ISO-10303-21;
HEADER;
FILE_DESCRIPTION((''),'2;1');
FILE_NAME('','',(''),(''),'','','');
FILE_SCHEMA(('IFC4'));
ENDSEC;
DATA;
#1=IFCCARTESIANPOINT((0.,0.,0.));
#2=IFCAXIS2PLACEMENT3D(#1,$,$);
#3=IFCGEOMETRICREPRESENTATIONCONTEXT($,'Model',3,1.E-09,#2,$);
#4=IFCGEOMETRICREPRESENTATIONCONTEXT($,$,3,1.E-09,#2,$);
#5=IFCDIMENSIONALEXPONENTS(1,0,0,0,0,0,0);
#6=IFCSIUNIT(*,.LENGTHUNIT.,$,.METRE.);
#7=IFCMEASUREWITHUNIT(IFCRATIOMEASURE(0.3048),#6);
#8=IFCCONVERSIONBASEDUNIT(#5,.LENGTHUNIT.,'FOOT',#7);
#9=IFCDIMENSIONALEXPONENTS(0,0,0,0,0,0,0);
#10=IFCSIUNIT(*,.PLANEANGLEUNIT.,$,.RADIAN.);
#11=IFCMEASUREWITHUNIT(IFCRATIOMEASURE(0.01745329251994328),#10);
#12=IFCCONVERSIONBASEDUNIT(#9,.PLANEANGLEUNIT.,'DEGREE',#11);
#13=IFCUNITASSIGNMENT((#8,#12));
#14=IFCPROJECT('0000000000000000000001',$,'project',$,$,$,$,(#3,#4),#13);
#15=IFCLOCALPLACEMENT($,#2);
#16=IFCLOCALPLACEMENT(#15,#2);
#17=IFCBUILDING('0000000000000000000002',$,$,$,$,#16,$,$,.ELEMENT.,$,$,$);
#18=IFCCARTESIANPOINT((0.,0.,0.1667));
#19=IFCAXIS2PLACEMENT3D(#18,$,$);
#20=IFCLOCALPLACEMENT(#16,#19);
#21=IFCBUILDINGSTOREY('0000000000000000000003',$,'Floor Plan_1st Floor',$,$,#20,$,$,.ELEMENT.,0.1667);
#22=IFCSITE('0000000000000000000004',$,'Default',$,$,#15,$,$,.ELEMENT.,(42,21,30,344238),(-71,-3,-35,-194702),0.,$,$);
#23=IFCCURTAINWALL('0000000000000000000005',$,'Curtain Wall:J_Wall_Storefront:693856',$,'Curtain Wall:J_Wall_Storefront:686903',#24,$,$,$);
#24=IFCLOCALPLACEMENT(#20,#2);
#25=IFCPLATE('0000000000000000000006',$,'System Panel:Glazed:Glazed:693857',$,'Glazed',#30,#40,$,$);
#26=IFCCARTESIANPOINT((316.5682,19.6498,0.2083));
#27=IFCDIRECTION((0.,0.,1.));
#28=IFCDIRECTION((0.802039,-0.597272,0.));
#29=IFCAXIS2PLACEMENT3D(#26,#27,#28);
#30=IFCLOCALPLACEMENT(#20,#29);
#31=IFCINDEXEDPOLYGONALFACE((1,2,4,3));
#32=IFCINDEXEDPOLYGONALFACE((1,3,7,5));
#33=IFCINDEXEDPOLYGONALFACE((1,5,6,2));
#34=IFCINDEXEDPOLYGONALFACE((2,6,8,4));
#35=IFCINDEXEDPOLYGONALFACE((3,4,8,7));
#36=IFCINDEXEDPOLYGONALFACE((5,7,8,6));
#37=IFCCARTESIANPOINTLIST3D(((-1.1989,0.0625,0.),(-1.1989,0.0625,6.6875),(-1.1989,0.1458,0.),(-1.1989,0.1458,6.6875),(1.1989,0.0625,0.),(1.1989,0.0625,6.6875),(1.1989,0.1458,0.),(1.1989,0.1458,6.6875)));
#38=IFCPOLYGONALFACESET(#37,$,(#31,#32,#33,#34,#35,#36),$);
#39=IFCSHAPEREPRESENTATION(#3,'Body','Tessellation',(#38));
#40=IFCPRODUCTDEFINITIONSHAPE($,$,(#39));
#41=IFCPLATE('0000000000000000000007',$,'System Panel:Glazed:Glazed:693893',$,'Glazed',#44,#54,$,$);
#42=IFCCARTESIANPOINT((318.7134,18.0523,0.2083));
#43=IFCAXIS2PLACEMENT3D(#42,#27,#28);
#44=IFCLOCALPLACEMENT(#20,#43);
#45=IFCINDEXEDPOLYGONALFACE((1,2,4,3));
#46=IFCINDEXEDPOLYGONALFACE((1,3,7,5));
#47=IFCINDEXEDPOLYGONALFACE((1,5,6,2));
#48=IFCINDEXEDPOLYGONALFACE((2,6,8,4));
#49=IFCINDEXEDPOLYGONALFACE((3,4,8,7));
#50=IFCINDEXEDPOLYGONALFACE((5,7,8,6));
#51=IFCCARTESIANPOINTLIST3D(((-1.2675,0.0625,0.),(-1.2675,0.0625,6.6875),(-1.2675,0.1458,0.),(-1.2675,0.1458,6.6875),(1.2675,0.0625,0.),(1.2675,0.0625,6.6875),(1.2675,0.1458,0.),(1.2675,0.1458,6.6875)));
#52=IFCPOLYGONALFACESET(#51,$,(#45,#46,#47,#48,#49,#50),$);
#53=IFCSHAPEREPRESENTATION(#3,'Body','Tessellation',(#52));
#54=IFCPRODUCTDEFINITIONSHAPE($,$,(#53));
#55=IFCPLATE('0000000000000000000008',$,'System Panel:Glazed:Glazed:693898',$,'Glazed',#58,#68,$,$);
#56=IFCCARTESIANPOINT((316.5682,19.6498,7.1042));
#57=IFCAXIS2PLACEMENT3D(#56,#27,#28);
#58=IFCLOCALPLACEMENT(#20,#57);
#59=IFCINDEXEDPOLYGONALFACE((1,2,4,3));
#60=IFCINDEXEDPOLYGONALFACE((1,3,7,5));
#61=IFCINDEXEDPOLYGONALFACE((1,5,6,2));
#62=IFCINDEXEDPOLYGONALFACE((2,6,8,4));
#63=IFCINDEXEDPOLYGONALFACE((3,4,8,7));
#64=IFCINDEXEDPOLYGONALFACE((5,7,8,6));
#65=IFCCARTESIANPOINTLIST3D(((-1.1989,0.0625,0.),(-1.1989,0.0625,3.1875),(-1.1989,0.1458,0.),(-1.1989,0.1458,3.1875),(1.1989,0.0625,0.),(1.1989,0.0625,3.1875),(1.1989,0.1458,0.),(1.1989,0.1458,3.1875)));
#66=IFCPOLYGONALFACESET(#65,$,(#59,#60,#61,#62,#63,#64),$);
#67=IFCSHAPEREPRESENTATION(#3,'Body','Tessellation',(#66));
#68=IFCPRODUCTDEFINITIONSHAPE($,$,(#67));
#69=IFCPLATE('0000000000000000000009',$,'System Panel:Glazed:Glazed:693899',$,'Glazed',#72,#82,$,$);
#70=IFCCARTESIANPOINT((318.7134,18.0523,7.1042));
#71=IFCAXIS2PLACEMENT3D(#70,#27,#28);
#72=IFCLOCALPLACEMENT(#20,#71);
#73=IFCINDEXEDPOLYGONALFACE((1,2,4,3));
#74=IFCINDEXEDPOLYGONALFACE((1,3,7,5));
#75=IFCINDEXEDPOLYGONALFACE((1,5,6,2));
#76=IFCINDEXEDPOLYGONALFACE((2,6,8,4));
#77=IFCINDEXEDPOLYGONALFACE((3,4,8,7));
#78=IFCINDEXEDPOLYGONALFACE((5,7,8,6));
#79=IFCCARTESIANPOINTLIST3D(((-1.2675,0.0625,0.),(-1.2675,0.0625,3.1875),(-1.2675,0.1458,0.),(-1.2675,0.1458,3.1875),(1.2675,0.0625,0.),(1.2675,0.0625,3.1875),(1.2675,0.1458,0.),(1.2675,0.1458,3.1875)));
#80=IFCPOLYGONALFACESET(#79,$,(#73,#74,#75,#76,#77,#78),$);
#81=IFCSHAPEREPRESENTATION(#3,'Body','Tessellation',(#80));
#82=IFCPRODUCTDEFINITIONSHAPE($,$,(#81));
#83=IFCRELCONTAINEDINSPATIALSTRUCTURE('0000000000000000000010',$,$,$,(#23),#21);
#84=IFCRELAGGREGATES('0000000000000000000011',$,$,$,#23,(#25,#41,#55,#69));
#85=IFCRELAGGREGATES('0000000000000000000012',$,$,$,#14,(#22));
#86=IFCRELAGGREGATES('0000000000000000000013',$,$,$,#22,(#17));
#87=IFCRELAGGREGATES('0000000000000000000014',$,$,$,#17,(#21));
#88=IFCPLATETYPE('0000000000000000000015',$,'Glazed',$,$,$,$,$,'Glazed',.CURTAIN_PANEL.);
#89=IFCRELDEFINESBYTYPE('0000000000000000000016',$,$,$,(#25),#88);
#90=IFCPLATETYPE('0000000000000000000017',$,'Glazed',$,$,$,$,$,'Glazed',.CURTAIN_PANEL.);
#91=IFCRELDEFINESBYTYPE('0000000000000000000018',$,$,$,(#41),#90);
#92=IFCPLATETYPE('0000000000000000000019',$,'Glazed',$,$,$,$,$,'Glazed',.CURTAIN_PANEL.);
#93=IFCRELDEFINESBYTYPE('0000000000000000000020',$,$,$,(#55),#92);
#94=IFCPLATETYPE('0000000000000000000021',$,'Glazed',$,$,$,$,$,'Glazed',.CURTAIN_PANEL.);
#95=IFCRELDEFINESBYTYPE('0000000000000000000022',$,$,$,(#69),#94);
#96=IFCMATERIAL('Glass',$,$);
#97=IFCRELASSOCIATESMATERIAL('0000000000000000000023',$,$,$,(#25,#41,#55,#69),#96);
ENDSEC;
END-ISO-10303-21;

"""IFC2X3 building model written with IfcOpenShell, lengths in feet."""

from ifc_helpers import new_model, entity, si_unit, converted_unit, frame, origin, origin_2d_with_axis, place, context, project, spatial, rectangle, extrude, source, transform, mapped, material, type_object, type_shapes, element, aggregate, save


model = new_model("IFC2X3")

# Units and contexts
model_context = context("Model", 3, precision=1e-09, world=origin())
context_of_model = context(None, 3, precision=1e-09, world=origin())
ifc_project = project(units=[converted_unit("LENGTHUNIT", "FOOT", entity("IfcRatioMeasure", 0.3048), si_unit("LENGTHUNIT", "METRE"), dimensions=[1, 0, 0, 0, 0, 0, 0]), converted_unit("PLANEANGLEUNIT", "DEGREE", entity("IfcRatioMeasure", 0.01745329251994328), si_unit("PLANEANGLEUNIT", "RADIAN"), dimensions=[0, 0, 0, 0, 0, 0, 0])], contexts=[model_context, context_of_model])

# Site, building, storey
site_placement = place(None, origin())
site = spatial("IfcSite", under=ifc_project, at=site_placement, Name="Default", CompositionType="ELEMENT", RefLatitude=(42, 21, 30, 344238), RefLongitude=(-71, -3, -35, -194702), RefElevation=0.0)
building_placement = place(site_placement, origin())
building = spatial("IfcBuilding", under=site, at=building_placement, CompositionType="ELEMENT")
storey_placement = place(building_placement, frame((0.0, 0.0, 0.1667)))
storey = spatial("IfcBuildingStorey", under=building, at=storey_placement, Name="Floor Plan_1st Floor", CompositionType="ELEMENT", Elevation=0.1667)

# Curtain wall
curtain_wall_placement = place(storey_placement, origin())
curtain_wall = element("IfcCurtainWall", 1, at=curtain_wall_placement, inside=storey, Name="Curtain Wall:J_Wall_Storefront:693856", ObjectType="Curtain Wall:J_Wall_Storefront:686903")

# Plates
ifc_material_1 = material(Name="Glass")
plate_type_1 = type_object("IfcPlateType", Name="Glazed", ElementType="Glazed", PredefinedType="CURTAIN_PANEL")
shared_shape_1 = source(origin(), model_context, "Body", "SweptSolid", [
    extrude(rectangle(XDim=0.0833, YDim=2.3978, at=origin_2d_with_axis()), frame((0.0, 0.1042, 0.0), z_axis=(0.0, 0.0, 1.0), x_axis=(0.0, 1.0, 0.0)), (0.0, 0.0, 1.0), 6.6875),
])
type_shapes(plate_type_1, [shared_shape_1])
plate_1_placement = place(storey_placement, frame((316.5682, 19.6498, 0.2083), z_axis=(0.0, 0.0, 1.0), x_axis=(0.802039, -0.597272, 0.0)))
plate_1 = element("IfcPlate", 2, at=plate_1_placement, type_object=plate_type_1, material=ifc_material_1, Name="System Panel:Glazed:Glazed:693857", ObjectType="Glazed", context=model_context, shape_type="MappedRepresentation", body=[
    mapped(shared_shape_1, transform((0.0, 0.0, 0.0), scale=1.0)),
])
plate_type_2 = type_object("IfcPlateType", Name="Glazed", ElementType="Glazed", PredefinedType="CURTAIN_PANEL")
shared_shape_2 = source(origin(), model_context, "Body", "SweptSolid", [
    extrude(rectangle(XDim=0.0833, YDim=2.5351, at=origin_2d_with_axis()), frame((0.0, 0.1042, 0.0), z_axis=(0.0, 0.0, 1.0), x_axis=(0.0, 1.0, 0.0)), (0.0, 0.0, 1.0), 6.6875),
])
type_shapes(plate_type_2, [shared_shape_2])
plate_2_placement = place(storey_placement, frame((318.7134, 18.0523, 0.2083), z_axis=(0.0, 0.0, 1.0), x_axis=(0.802039, -0.597272, 0.0)))
plate_2 = element("IfcPlate", 3, at=plate_2_placement, type_object=plate_type_2, material=ifc_material_1, Name="System Panel:Glazed:Glazed:693893", ObjectType="Glazed", context=model_context, shape_type="MappedRepresentation", body=[
    mapped(shared_shape_2, transform((0.0, 0.0, 0.0), scale=1.0)),
])
plate_type_3 = type_object("IfcPlateType", Name="Glazed", ElementType="Glazed", PredefinedType="CURTAIN_PANEL")
shared_shape_3 = source(origin(), model_context, "Body", "SweptSolid", [
    extrude(rectangle(XDim=0.0833, YDim=2.3978, at=origin_2d_with_axis()), frame((0.0, 0.1042, 0.0), z_axis=(0.0, 0.0, 1.0), x_axis=(0.0, 1.0, 0.0)), (0.0, 0.0, 1.0), 3.1875),
])
type_shapes(plate_type_3, [shared_shape_3])
plate_3_placement = place(storey_placement, frame((316.5682, 19.6498, 7.1042), z_axis=(0.0, 0.0, 1.0), x_axis=(0.802039, -0.597272, 0.0)))
plate_3 = element("IfcPlate", 4, at=plate_3_placement, type_object=plate_type_3, material=ifc_material_1, Name="System Panel:Glazed:Glazed:693898", ObjectType="Glazed", context=model_context, shape_type="MappedRepresentation", body=[
    mapped(shared_shape_3, transform((0.0, 0.0, 0.0), scale=1.0)),
])
plate_type_4 = type_object("IfcPlateType", Name="Glazed", ElementType="Glazed", PredefinedType="CURTAIN_PANEL")
shared_shape_4 = source(origin(), model_context, "Body", "SweptSolid", [
    extrude(rectangle(XDim=0.0833, YDim=2.5351, at=origin_2d_with_axis()), frame((0.0, 0.1042, 0.0), z_axis=(0.0, 0.0, 1.0), x_axis=(0.0, 1.0, 0.0)), (0.0, 0.0, 1.0), 3.1875),
])
type_shapes(plate_type_4, [shared_shape_4])
plate_4_placement = place(storey_placement, frame((318.7134, 18.0523, 7.1042), z_axis=(0.0, 0.0, 1.0), x_axis=(0.802039, -0.597272, 0.0)))
plate_4 = element("IfcPlate", 5, at=plate_4_placement, type_object=plate_type_4, material=ifc_material_1, Name="System Panel:Glazed:Glazed:693899", ObjectType="Glazed", context=model_context, shape_type="MappedRepresentation", body=[
    mapped(shared_shape_4, transform((0.0, 0.0, 0.0), scale=1.0)),
])
aggregate(curtain_wall, [plate_1, plate_2, plate_3, plate_4])

save(model, "model.ifc")
